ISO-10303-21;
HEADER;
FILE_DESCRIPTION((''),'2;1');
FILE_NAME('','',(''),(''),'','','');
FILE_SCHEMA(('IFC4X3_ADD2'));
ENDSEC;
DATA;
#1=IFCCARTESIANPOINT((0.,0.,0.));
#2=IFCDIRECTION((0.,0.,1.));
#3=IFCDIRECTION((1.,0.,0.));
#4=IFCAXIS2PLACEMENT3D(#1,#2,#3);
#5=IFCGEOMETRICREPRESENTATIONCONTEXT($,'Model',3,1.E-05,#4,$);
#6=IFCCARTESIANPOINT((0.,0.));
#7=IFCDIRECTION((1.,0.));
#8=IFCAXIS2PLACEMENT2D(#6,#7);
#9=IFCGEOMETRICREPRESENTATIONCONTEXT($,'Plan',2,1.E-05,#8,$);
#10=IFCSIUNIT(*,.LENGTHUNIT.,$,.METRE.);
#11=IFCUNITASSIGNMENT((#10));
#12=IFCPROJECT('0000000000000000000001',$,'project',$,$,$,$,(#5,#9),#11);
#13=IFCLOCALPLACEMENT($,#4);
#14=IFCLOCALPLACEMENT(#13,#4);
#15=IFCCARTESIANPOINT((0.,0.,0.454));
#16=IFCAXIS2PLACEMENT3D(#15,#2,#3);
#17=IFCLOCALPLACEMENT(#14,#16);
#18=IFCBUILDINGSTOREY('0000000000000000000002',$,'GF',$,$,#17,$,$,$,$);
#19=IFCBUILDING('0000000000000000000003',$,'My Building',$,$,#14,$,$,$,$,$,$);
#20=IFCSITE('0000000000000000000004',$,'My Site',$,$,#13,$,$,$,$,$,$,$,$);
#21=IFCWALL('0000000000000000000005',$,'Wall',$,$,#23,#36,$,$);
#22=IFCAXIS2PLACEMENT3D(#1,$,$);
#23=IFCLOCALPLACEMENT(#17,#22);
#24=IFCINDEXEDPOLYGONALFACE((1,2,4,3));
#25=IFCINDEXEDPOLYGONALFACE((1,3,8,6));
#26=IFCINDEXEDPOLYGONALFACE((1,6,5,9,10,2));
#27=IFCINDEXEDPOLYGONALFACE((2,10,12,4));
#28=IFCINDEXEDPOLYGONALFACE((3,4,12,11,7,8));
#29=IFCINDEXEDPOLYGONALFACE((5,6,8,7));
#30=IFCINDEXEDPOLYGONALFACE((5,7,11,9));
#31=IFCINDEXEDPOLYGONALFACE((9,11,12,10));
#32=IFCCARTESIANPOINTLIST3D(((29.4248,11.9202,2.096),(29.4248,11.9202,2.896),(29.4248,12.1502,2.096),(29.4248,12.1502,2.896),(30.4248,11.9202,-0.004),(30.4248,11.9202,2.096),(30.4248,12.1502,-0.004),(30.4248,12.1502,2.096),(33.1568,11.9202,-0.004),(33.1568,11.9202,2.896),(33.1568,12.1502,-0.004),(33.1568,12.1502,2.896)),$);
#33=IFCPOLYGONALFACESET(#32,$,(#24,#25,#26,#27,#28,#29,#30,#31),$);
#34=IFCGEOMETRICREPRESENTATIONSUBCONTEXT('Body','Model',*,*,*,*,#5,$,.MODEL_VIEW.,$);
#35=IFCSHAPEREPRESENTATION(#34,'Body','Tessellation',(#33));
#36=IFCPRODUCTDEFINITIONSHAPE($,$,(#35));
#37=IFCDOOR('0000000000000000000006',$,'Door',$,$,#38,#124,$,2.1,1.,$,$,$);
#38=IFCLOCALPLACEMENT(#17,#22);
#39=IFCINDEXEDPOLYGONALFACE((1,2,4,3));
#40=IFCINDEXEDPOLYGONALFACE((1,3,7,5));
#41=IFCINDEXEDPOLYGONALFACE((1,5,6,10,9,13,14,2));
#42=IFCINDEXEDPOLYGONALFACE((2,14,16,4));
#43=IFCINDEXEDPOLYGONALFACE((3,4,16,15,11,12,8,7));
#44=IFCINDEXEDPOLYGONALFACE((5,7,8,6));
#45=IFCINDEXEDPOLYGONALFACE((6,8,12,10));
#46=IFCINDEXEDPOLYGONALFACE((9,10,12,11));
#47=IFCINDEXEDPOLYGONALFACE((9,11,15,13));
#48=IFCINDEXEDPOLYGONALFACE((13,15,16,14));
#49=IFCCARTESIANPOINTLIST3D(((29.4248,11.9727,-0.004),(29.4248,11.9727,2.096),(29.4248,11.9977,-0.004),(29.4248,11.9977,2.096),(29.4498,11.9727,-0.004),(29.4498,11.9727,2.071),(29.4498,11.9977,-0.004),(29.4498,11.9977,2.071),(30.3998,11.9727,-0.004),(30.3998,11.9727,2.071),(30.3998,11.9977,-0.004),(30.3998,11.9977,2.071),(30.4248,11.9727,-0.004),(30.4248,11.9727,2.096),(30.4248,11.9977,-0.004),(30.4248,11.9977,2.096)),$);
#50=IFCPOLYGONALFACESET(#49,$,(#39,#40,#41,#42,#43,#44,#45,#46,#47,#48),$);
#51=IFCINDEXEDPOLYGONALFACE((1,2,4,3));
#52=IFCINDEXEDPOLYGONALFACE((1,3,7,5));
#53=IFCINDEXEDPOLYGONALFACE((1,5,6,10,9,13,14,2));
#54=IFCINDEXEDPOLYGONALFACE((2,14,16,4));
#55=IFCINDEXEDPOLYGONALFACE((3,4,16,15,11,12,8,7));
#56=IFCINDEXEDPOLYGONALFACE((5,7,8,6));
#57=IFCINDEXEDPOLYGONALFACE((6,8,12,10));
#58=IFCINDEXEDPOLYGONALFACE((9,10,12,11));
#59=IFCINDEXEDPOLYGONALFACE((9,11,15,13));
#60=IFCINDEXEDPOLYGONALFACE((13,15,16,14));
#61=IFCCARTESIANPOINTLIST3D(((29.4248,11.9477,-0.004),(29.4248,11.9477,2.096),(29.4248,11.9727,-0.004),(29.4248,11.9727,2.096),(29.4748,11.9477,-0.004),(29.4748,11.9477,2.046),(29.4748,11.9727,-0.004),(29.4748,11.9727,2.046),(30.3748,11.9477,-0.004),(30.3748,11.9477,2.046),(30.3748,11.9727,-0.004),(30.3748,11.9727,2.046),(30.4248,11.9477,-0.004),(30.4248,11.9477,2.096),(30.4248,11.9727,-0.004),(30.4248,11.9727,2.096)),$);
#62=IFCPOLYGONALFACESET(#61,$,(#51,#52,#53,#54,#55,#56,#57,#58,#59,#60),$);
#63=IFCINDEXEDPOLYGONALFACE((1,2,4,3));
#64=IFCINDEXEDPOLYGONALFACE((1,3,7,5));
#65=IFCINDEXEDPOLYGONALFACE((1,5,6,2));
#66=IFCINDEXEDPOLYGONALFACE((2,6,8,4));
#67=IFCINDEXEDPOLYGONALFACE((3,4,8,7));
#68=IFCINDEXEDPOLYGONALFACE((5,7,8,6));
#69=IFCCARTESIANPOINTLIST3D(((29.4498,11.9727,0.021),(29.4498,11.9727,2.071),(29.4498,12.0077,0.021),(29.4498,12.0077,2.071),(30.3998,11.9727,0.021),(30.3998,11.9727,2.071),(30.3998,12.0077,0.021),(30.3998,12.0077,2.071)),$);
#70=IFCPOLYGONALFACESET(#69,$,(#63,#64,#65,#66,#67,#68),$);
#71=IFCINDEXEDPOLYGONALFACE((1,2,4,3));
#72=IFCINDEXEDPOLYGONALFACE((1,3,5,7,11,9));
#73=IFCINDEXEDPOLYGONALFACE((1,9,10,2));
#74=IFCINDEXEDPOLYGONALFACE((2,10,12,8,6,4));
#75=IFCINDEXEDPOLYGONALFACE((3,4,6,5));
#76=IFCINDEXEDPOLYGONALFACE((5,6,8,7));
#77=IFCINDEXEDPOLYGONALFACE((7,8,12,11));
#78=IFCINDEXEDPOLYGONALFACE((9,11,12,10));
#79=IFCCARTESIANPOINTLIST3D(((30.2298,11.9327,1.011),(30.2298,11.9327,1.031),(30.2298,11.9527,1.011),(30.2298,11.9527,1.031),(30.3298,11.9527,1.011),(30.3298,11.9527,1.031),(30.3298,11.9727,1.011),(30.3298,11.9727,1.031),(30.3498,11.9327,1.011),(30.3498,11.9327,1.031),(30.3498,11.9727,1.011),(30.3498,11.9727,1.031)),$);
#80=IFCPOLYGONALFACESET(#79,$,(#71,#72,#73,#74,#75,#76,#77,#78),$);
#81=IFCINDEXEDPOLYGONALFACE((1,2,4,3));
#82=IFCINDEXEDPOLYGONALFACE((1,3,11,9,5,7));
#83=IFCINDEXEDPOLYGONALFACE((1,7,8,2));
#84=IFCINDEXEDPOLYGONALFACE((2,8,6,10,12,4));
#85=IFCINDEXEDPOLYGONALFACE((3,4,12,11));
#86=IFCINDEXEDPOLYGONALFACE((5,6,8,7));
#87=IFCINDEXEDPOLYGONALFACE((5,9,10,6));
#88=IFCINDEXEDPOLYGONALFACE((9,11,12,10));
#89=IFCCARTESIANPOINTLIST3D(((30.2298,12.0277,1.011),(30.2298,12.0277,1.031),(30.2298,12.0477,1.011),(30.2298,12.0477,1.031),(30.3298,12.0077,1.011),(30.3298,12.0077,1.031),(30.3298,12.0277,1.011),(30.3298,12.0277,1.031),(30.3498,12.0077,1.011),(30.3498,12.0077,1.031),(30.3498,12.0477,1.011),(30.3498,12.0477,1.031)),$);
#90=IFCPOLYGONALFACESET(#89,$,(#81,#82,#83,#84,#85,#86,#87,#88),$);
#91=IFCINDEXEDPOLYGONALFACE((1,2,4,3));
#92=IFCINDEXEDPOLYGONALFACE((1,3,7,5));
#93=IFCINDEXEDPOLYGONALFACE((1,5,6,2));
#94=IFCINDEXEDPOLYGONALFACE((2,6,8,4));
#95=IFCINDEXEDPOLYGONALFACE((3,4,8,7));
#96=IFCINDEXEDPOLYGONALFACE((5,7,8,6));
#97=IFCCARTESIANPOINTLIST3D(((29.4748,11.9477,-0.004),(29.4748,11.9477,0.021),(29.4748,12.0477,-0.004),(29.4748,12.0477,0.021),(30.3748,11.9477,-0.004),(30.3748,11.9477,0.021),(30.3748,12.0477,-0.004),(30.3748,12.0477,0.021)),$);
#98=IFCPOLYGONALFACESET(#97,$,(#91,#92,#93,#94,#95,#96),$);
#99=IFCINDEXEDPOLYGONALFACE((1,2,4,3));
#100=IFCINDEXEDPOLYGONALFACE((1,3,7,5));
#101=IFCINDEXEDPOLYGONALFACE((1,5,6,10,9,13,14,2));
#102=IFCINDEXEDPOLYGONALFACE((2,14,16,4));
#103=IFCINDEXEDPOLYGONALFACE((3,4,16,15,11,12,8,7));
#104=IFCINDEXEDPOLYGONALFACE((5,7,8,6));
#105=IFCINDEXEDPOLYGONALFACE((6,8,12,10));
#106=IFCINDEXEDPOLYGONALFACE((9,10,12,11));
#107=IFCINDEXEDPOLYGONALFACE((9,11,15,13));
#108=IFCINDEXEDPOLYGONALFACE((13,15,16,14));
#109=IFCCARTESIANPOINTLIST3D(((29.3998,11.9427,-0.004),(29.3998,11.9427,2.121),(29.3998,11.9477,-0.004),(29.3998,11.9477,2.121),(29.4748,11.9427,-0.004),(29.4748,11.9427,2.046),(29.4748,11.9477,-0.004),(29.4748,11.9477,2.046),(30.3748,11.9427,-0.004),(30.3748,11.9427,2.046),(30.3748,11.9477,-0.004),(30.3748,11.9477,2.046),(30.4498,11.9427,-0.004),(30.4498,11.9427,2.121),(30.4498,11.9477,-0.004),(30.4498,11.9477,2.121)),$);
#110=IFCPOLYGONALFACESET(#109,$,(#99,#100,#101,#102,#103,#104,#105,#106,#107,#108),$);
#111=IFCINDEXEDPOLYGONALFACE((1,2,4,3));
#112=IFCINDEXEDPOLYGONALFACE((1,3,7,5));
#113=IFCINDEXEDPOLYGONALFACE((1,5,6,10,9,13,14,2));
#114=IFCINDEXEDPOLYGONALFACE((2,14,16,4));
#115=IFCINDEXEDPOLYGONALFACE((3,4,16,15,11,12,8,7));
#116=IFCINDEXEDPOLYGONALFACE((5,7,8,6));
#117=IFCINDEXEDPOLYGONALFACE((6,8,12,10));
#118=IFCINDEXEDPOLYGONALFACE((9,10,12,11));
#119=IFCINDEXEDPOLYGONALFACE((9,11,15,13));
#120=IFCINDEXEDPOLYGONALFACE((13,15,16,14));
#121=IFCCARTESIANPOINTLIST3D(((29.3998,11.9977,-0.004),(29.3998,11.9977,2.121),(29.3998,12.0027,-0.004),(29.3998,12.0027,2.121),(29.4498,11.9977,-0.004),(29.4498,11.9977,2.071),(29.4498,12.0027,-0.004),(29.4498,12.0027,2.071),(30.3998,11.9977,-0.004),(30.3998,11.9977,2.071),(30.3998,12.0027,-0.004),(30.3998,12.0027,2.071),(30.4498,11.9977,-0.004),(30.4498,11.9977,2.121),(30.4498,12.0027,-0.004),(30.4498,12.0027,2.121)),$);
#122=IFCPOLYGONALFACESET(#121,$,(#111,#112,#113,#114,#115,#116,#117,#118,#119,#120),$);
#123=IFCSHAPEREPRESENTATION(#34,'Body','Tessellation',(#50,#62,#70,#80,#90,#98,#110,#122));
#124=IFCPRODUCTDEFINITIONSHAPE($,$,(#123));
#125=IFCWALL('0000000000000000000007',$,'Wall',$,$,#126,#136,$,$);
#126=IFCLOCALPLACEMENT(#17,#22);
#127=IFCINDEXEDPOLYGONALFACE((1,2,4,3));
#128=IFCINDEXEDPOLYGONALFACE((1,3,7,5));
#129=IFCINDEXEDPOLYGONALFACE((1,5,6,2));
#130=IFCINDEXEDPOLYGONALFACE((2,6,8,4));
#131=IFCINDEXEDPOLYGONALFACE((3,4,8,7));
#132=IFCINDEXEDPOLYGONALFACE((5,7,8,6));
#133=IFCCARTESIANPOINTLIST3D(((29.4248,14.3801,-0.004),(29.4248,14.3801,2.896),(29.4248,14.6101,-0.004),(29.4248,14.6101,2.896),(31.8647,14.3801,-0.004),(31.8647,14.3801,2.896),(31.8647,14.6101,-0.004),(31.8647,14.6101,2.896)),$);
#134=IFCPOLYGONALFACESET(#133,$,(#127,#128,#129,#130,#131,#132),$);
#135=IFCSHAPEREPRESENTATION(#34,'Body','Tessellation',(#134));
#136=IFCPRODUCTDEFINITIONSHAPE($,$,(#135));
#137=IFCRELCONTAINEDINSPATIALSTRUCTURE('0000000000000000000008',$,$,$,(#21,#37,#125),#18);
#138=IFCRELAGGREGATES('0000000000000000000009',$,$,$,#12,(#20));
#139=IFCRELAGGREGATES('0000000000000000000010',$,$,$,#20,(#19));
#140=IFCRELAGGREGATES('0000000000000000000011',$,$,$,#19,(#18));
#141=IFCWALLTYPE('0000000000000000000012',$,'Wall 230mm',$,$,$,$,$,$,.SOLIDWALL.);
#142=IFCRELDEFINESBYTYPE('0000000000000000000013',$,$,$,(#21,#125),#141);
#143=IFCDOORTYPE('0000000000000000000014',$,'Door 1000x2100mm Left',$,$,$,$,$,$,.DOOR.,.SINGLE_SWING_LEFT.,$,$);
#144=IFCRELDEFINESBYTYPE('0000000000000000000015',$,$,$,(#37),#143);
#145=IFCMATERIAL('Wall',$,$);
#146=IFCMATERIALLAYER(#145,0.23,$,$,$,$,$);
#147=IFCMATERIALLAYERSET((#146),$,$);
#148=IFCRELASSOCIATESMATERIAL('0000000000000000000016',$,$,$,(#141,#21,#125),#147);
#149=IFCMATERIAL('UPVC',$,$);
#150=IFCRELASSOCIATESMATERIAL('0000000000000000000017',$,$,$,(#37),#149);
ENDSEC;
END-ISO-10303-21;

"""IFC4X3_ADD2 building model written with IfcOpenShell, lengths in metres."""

from ifc_helpers import new_model, entity, si_unit, frame, origin_with_axes, origin_2d_with_axis, place, context, subcontext, project, spatial, line, indexed_curve, outline, extrude, shape, source, transform, mapped, material, layer, layer_set, layer_usage, type_object, type_shapes, element, fill, save


model = new_model("IFC4X3_ADD2")

# Units and contexts
model_context = context("Model", 3, precision=1e-05, world=origin_with_axes())
plan_context = context("Plan", 2, precision=1e-05, world=origin_2d_with_axis())
body_context_1 = subcontext(model_context, "Body", "Model", "MODEL_VIEW")
body_context_2 = subcontext(plan_context, "Body", "Plan", "PLAN_VIEW")
ifc_project = project(units=[si_unit("LENGTHUNIT", "METRE")], contexts=[model_context, plan_context])

# Site, building, storey
site_placement = place(None, origin_with_axes())
site = spatial("IfcSite", under=ifc_project, at=site_placement, Name="My Site")
building_placement = place(site_placement, origin_with_axes())
building = spatial("IfcBuilding", under=site, at=building_placement, Name="My Building")
storey_placement = place(building_placement, frame((0.0, 0.0, 0.454), z_axis=(0.0, 0.0, 1.0), x_axis=(1.0, 0.0, 0.0)))
storey = spatial("IfcBuildingStorey", under=building, at=storey_placement, Name="GF")

# Shared definitions
ifc_material_1 = material(Name="Wall")

# Shared definitions
ifc_material_2 = material(Name="UPVC")

# Shared definitions
ifc_layer_1 = layer(ifc_material_1, 0.23)
ifc_layer_set_1 = layer_set([ifc_layer_1])
wall_type_1 = type_object("IfcWallType", Name="Wall 230mm", PredefinedType="SOLIDWALL", material=ifc_layer_set_1)

# Wall, opening, door
ifc_layer_usage_1 = layer_usage(ifc_layer_set_1, "AXIS2", "POSITIVE", 0.0)
wall_1_placement = place(storey_placement, frame((33.1568, 12.1502, -0.004), z_axis=(0.0, 0.0, 1.0), x_axis=(-1.0, 0.0, 0.0)))
wall_1 = element("IfcWall", 1, at=wall_1_placement, inside=storey, type_object=wall_type_1, material=ifc_layer_usage_1, Name="Wall", context=body_context_1, shape_type="SweptSolid", body=[
    extrude(outline(indexed_curve([(0.0, 0.0), (0.0, 0.23), (3.732, 0.23), (3.732, 0.0), (0.0, 0.0)], self_intersect=False)), origin_with_axes(), (0.0, 0.0, 1.0), 2.9),
])
shared_shape_1 = source(origin_with_axes(), body_context_1, "Body", "SweptSolid", [
    extrude(outline(indexed_curve([(0.0, 0.0), (1.0, 0.0), (1.0, 2.1), (0.0, 2.1)], segments=[line(1, 2, 3, 4, 1)])), frame((0.0, -0.6, 0.0), z_axis=(0.0, -1.0, 0.0), x_axis=(1.0, 0.0, 0.0)), (0.0, 0.0, -1.0), 1.2),
])
opening_1_placement = place(wall_1_placement, frame((3.732, 0.2024, 0.0), z_axis=(0.0, 0.0, 1.0), x_axis=(-1.0, 0.0, 0.0)))
opening_1 = element("IfcOpeningElement", 2, at=opening_1_placement, cuts=wall_1, PredefinedType="OPENING", context=body_context_1, shape_type="MappedRepresentation", body=[
    mapped(shared_shape_1, transform((0.0, 0.0, 0.0), x_axis=(1.0, 0.0, 0.0), y_axis=(0.0, 1.0, 0.0), z_axis=(0.0, 0.0, 1.0), scale=1.0)),
])
door_type_1 = type_object("IfcDoorType", Name="Door 1000x2100mm Left", OperationType="SINGLE_SWING_LEFT", PredefinedType="DOOR")
shared_shape_2 = source(origin_with_axes(), body_context_1, "Body", "SweptSolid", [
    extrude(outline(indexed_curve([(0.0, 0.0), (0.0, 2.1), (1.0, 2.1), (1.0, 0.0), (0.975, 0.0), (0.975, 2.075), (0.025, 2.075), (0.025, 0.0)], segments=[line(1, 2, 3, 4, 5, 6, 7, 8, 1)])), frame((0.0, 0.025, 0.0), z_axis=(0.0, -1.0, 0.0), x_axis=(1.0, 0.0, 0.0)), (0.0, 0.0, -1.0), 0.025),
    extrude(outline(indexed_curve([(0.0, 0.0), (0.0, 2.1), (1.0, 2.1), (1.0, 0.0), (0.95, 0.0), (0.95, 2.05), (0.05, 2.05), (0.05, 0.0)], segments=[line(1, 2, 3, 4, 5, 6, 7, 8, 1)])), frame((0.0, 0.0, 0.0), z_axis=(0.0, -1.0, 0.0), x_axis=(1.0, 0.0, 0.0)), (0.0, 0.0, -1.0), 0.025),
    extrude(outline(indexed_curve([(0.0, 0.0), (0.95, 0.0), (0.95, 0.035), (0.0, 0.035)], segments=[line(1, 2, 3, 4, 1)])), frame((0.025, 0.025, 0.025), z_axis=(0.0, 0.0, 1.0), x_axis=(1.0, 0.0, 0.0)), (0.0, 0.0, 1.0), 2.05),
    extrude(outline(indexed_curve([(0.0, 0.0), (0.0, -0.04), (-0.12, -0.04), (-0.12, -0.02), (-0.02, -0.02), (-0.02, 0.0)], segments=[line(1, 2, 3, 4, 5, 6, 1)])), frame((0.925, 0.025, 1.015), z_axis=(0.0, 0.0, 1.0), x_axis=(1.0, 0.0, 0.0)), (0.0, 0.0, 1.0), 0.02),
    extrude(outline(indexed_curve([(0.0, 0.0), (0.0, 0.04), (-0.12, 0.04), (-0.12, 0.02), (-0.02, 0.02), (-0.02, 0.0)], segments=[line(1, 2, 3, 4, 5, 6, 1)])), frame((0.925, 0.06, 1.015), z_axis=(0.0, 0.0, 1.0), x_axis=(1.0, 0.0, 0.0)), (0.0, 0.0, 1.0), 0.02),
    extrude(outline(indexed_curve([(0.0, 0.0), (0.9, 0.0), (0.9, 0.1), (0.0, 0.1)], segments=[line(1, 2, 3, 4, 1)])), frame((0.05, 0.0, 0.0), z_axis=(0.0, 0.0, 1.0), x_axis=(1.0, 0.0, 0.0)), (0.0, 0.0, 1.0), 0.025),
    extrude(outline(indexed_curve([(0.0, 0.0), (0.0, 2.125), (1.05, 2.125), (1.05, 0.0), (0.975, 0.0), (0.975, 2.05), (0.075, 2.05), (0.075, 0.0)], segments=[line(1, 2, 3, 4, 5, 6, 7, 8, 1)])), frame((-0.025, -0.005, 0.0), z_axis=(0.0, -1.0, 0.0), x_axis=(1.0, 0.0, 0.0)), (0.0, 0.0, -1.0), 0.005),
    extrude(outline(indexed_curve([(0.0, 0.0), (0.0, 2.125), (1.05, 2.125), (1.05, 0.0), (1.0, 0.0), (1.0, 2.075), (0.05, 2.075), (0.05, 0.0)], segments=[line(1, 2, 3, 4, 5, 6, 7, 8, 1)])), frame((-0.025, 0.05, 0.0), z_axis=(0.0, -1.0, 0.0), x_axis=(1.0, 0.0, 0.0)), (0.0, 0.0, -1.0), 0.005),
])
shared_shape_3 = source(origin_with_axes(), body_context_2, "Body", "Curve2D", [
    entity("IfcIndexedPolyCurve", entity("IfcCartesianPointList2D", [[0.0, 0.0], [0.0, 0.05], [0.025, 0.05], [0.025, 0.025], [0.05, 0.025], [0.05, 0.0]]), [entity("IfcLineIndex", [1, 2, 3, 4, 5, 6, 1])]),
    entity("IfcIndexedPolyCurve", entity("IfcCartesianPointList2D", [[1.0, 0.0], [1.0, 0.05], [0.975, 0.05], [0.975, 0.025], [0.95, 0.025], [0.95, 0.0]]), [entity("IfcLineIndex", [1, 2, 3, 4, 5, 6, 1])]),
    entity("IfcTrimmedCurve", entity("IfcEllipse", entity("IfcAxis2Placement2D", entity("IfcCartesianPoint", [0.06, 0.05]), entity("IfcDirection", [1.0, 0.0])), 0.915, 0.95), [entity("IfcCartesianPoint", [0.975, 0.05])], [entity("IfcCartesianPoint", [0.06, 1.0])], True, "CARTESIAN"),
    entity("IfcIndexedPolyCurve", entity("IfcCartesianPointList2D", [[0.025, 0.05], [0.06, 0.05], [0.06, 1.0], [0.025, 1.0]]), [entity("IfcLineIndex", [1, 2, 3, 4, 1])]),
])
type_shapes(door_type_1, [shared_shape_2, shared_shape_3])
door_1_placement = place(opening_1_placement, frame((0.0, 0.0, 0.0), z_axis=(0.0, 0.0, 1.0), x_axis=(1.0, 0.0, 0.0)))
door_1 = element("IfcDoor", 3, at=door_1_placement, inside=storey, type_object=door_type_1, material=ifc_material_2, Name="Door", OverallHeight=2.1, OverallWidth=1.0, shapes=[
    shape(body_context_1, "Body", "MappedRepresentation", [mapped(shared_shape_2, transform((0.0, 0.0, 0.0), x_axis=(1.0, 0.0, 0.0), y_axis=(0.0, 1.0, 0.0), z_axis=(0.0, 0.0, 1.0), scale=1.0))]),
    shape(body_context_2, "Body", "MappedRepresentation", [mapped(shared_shape_3, transform((0.0, 0.0, 0.0), x_axis=(1.0, 0.0, 0.0), y_axis=(0.0, 1.0, 0.0), z_axis=(0.0, 0.0, 1.0), scale=1.0))]),
])
fill(opening_1, door_1)

# Wall
ifc_layer_usage_2 = layer_usage(ifc_layer_set_1, "AXIS2", "POSITIVE", 0.0)
wall_2_placement = place(storey_placement, frame((31.8647, 14.6101, -0.004), z_axis=(0.0, 0.0, 1.0), x_axis=(-1.0, 0.0, 0.0)))
element("IfcWall", 4, at=wall_2_placement, inside=storey, type_object=wall_type_1, material=ifc_layer_usage_2, Name="Wall", context=body_context_1, shape_type="SweptSolid", body=[
    extrude(outline(indexed_curve([(0.0, 0.0), (0.0, 0.23), (2.44, 0.23), (2.44, 0.0), (0.0, 0.0)], self_intersect=False)), origin_with_axes(), (0.0, 0.0, 1.0), 2.9),
])

save(model, "model.ifc")
